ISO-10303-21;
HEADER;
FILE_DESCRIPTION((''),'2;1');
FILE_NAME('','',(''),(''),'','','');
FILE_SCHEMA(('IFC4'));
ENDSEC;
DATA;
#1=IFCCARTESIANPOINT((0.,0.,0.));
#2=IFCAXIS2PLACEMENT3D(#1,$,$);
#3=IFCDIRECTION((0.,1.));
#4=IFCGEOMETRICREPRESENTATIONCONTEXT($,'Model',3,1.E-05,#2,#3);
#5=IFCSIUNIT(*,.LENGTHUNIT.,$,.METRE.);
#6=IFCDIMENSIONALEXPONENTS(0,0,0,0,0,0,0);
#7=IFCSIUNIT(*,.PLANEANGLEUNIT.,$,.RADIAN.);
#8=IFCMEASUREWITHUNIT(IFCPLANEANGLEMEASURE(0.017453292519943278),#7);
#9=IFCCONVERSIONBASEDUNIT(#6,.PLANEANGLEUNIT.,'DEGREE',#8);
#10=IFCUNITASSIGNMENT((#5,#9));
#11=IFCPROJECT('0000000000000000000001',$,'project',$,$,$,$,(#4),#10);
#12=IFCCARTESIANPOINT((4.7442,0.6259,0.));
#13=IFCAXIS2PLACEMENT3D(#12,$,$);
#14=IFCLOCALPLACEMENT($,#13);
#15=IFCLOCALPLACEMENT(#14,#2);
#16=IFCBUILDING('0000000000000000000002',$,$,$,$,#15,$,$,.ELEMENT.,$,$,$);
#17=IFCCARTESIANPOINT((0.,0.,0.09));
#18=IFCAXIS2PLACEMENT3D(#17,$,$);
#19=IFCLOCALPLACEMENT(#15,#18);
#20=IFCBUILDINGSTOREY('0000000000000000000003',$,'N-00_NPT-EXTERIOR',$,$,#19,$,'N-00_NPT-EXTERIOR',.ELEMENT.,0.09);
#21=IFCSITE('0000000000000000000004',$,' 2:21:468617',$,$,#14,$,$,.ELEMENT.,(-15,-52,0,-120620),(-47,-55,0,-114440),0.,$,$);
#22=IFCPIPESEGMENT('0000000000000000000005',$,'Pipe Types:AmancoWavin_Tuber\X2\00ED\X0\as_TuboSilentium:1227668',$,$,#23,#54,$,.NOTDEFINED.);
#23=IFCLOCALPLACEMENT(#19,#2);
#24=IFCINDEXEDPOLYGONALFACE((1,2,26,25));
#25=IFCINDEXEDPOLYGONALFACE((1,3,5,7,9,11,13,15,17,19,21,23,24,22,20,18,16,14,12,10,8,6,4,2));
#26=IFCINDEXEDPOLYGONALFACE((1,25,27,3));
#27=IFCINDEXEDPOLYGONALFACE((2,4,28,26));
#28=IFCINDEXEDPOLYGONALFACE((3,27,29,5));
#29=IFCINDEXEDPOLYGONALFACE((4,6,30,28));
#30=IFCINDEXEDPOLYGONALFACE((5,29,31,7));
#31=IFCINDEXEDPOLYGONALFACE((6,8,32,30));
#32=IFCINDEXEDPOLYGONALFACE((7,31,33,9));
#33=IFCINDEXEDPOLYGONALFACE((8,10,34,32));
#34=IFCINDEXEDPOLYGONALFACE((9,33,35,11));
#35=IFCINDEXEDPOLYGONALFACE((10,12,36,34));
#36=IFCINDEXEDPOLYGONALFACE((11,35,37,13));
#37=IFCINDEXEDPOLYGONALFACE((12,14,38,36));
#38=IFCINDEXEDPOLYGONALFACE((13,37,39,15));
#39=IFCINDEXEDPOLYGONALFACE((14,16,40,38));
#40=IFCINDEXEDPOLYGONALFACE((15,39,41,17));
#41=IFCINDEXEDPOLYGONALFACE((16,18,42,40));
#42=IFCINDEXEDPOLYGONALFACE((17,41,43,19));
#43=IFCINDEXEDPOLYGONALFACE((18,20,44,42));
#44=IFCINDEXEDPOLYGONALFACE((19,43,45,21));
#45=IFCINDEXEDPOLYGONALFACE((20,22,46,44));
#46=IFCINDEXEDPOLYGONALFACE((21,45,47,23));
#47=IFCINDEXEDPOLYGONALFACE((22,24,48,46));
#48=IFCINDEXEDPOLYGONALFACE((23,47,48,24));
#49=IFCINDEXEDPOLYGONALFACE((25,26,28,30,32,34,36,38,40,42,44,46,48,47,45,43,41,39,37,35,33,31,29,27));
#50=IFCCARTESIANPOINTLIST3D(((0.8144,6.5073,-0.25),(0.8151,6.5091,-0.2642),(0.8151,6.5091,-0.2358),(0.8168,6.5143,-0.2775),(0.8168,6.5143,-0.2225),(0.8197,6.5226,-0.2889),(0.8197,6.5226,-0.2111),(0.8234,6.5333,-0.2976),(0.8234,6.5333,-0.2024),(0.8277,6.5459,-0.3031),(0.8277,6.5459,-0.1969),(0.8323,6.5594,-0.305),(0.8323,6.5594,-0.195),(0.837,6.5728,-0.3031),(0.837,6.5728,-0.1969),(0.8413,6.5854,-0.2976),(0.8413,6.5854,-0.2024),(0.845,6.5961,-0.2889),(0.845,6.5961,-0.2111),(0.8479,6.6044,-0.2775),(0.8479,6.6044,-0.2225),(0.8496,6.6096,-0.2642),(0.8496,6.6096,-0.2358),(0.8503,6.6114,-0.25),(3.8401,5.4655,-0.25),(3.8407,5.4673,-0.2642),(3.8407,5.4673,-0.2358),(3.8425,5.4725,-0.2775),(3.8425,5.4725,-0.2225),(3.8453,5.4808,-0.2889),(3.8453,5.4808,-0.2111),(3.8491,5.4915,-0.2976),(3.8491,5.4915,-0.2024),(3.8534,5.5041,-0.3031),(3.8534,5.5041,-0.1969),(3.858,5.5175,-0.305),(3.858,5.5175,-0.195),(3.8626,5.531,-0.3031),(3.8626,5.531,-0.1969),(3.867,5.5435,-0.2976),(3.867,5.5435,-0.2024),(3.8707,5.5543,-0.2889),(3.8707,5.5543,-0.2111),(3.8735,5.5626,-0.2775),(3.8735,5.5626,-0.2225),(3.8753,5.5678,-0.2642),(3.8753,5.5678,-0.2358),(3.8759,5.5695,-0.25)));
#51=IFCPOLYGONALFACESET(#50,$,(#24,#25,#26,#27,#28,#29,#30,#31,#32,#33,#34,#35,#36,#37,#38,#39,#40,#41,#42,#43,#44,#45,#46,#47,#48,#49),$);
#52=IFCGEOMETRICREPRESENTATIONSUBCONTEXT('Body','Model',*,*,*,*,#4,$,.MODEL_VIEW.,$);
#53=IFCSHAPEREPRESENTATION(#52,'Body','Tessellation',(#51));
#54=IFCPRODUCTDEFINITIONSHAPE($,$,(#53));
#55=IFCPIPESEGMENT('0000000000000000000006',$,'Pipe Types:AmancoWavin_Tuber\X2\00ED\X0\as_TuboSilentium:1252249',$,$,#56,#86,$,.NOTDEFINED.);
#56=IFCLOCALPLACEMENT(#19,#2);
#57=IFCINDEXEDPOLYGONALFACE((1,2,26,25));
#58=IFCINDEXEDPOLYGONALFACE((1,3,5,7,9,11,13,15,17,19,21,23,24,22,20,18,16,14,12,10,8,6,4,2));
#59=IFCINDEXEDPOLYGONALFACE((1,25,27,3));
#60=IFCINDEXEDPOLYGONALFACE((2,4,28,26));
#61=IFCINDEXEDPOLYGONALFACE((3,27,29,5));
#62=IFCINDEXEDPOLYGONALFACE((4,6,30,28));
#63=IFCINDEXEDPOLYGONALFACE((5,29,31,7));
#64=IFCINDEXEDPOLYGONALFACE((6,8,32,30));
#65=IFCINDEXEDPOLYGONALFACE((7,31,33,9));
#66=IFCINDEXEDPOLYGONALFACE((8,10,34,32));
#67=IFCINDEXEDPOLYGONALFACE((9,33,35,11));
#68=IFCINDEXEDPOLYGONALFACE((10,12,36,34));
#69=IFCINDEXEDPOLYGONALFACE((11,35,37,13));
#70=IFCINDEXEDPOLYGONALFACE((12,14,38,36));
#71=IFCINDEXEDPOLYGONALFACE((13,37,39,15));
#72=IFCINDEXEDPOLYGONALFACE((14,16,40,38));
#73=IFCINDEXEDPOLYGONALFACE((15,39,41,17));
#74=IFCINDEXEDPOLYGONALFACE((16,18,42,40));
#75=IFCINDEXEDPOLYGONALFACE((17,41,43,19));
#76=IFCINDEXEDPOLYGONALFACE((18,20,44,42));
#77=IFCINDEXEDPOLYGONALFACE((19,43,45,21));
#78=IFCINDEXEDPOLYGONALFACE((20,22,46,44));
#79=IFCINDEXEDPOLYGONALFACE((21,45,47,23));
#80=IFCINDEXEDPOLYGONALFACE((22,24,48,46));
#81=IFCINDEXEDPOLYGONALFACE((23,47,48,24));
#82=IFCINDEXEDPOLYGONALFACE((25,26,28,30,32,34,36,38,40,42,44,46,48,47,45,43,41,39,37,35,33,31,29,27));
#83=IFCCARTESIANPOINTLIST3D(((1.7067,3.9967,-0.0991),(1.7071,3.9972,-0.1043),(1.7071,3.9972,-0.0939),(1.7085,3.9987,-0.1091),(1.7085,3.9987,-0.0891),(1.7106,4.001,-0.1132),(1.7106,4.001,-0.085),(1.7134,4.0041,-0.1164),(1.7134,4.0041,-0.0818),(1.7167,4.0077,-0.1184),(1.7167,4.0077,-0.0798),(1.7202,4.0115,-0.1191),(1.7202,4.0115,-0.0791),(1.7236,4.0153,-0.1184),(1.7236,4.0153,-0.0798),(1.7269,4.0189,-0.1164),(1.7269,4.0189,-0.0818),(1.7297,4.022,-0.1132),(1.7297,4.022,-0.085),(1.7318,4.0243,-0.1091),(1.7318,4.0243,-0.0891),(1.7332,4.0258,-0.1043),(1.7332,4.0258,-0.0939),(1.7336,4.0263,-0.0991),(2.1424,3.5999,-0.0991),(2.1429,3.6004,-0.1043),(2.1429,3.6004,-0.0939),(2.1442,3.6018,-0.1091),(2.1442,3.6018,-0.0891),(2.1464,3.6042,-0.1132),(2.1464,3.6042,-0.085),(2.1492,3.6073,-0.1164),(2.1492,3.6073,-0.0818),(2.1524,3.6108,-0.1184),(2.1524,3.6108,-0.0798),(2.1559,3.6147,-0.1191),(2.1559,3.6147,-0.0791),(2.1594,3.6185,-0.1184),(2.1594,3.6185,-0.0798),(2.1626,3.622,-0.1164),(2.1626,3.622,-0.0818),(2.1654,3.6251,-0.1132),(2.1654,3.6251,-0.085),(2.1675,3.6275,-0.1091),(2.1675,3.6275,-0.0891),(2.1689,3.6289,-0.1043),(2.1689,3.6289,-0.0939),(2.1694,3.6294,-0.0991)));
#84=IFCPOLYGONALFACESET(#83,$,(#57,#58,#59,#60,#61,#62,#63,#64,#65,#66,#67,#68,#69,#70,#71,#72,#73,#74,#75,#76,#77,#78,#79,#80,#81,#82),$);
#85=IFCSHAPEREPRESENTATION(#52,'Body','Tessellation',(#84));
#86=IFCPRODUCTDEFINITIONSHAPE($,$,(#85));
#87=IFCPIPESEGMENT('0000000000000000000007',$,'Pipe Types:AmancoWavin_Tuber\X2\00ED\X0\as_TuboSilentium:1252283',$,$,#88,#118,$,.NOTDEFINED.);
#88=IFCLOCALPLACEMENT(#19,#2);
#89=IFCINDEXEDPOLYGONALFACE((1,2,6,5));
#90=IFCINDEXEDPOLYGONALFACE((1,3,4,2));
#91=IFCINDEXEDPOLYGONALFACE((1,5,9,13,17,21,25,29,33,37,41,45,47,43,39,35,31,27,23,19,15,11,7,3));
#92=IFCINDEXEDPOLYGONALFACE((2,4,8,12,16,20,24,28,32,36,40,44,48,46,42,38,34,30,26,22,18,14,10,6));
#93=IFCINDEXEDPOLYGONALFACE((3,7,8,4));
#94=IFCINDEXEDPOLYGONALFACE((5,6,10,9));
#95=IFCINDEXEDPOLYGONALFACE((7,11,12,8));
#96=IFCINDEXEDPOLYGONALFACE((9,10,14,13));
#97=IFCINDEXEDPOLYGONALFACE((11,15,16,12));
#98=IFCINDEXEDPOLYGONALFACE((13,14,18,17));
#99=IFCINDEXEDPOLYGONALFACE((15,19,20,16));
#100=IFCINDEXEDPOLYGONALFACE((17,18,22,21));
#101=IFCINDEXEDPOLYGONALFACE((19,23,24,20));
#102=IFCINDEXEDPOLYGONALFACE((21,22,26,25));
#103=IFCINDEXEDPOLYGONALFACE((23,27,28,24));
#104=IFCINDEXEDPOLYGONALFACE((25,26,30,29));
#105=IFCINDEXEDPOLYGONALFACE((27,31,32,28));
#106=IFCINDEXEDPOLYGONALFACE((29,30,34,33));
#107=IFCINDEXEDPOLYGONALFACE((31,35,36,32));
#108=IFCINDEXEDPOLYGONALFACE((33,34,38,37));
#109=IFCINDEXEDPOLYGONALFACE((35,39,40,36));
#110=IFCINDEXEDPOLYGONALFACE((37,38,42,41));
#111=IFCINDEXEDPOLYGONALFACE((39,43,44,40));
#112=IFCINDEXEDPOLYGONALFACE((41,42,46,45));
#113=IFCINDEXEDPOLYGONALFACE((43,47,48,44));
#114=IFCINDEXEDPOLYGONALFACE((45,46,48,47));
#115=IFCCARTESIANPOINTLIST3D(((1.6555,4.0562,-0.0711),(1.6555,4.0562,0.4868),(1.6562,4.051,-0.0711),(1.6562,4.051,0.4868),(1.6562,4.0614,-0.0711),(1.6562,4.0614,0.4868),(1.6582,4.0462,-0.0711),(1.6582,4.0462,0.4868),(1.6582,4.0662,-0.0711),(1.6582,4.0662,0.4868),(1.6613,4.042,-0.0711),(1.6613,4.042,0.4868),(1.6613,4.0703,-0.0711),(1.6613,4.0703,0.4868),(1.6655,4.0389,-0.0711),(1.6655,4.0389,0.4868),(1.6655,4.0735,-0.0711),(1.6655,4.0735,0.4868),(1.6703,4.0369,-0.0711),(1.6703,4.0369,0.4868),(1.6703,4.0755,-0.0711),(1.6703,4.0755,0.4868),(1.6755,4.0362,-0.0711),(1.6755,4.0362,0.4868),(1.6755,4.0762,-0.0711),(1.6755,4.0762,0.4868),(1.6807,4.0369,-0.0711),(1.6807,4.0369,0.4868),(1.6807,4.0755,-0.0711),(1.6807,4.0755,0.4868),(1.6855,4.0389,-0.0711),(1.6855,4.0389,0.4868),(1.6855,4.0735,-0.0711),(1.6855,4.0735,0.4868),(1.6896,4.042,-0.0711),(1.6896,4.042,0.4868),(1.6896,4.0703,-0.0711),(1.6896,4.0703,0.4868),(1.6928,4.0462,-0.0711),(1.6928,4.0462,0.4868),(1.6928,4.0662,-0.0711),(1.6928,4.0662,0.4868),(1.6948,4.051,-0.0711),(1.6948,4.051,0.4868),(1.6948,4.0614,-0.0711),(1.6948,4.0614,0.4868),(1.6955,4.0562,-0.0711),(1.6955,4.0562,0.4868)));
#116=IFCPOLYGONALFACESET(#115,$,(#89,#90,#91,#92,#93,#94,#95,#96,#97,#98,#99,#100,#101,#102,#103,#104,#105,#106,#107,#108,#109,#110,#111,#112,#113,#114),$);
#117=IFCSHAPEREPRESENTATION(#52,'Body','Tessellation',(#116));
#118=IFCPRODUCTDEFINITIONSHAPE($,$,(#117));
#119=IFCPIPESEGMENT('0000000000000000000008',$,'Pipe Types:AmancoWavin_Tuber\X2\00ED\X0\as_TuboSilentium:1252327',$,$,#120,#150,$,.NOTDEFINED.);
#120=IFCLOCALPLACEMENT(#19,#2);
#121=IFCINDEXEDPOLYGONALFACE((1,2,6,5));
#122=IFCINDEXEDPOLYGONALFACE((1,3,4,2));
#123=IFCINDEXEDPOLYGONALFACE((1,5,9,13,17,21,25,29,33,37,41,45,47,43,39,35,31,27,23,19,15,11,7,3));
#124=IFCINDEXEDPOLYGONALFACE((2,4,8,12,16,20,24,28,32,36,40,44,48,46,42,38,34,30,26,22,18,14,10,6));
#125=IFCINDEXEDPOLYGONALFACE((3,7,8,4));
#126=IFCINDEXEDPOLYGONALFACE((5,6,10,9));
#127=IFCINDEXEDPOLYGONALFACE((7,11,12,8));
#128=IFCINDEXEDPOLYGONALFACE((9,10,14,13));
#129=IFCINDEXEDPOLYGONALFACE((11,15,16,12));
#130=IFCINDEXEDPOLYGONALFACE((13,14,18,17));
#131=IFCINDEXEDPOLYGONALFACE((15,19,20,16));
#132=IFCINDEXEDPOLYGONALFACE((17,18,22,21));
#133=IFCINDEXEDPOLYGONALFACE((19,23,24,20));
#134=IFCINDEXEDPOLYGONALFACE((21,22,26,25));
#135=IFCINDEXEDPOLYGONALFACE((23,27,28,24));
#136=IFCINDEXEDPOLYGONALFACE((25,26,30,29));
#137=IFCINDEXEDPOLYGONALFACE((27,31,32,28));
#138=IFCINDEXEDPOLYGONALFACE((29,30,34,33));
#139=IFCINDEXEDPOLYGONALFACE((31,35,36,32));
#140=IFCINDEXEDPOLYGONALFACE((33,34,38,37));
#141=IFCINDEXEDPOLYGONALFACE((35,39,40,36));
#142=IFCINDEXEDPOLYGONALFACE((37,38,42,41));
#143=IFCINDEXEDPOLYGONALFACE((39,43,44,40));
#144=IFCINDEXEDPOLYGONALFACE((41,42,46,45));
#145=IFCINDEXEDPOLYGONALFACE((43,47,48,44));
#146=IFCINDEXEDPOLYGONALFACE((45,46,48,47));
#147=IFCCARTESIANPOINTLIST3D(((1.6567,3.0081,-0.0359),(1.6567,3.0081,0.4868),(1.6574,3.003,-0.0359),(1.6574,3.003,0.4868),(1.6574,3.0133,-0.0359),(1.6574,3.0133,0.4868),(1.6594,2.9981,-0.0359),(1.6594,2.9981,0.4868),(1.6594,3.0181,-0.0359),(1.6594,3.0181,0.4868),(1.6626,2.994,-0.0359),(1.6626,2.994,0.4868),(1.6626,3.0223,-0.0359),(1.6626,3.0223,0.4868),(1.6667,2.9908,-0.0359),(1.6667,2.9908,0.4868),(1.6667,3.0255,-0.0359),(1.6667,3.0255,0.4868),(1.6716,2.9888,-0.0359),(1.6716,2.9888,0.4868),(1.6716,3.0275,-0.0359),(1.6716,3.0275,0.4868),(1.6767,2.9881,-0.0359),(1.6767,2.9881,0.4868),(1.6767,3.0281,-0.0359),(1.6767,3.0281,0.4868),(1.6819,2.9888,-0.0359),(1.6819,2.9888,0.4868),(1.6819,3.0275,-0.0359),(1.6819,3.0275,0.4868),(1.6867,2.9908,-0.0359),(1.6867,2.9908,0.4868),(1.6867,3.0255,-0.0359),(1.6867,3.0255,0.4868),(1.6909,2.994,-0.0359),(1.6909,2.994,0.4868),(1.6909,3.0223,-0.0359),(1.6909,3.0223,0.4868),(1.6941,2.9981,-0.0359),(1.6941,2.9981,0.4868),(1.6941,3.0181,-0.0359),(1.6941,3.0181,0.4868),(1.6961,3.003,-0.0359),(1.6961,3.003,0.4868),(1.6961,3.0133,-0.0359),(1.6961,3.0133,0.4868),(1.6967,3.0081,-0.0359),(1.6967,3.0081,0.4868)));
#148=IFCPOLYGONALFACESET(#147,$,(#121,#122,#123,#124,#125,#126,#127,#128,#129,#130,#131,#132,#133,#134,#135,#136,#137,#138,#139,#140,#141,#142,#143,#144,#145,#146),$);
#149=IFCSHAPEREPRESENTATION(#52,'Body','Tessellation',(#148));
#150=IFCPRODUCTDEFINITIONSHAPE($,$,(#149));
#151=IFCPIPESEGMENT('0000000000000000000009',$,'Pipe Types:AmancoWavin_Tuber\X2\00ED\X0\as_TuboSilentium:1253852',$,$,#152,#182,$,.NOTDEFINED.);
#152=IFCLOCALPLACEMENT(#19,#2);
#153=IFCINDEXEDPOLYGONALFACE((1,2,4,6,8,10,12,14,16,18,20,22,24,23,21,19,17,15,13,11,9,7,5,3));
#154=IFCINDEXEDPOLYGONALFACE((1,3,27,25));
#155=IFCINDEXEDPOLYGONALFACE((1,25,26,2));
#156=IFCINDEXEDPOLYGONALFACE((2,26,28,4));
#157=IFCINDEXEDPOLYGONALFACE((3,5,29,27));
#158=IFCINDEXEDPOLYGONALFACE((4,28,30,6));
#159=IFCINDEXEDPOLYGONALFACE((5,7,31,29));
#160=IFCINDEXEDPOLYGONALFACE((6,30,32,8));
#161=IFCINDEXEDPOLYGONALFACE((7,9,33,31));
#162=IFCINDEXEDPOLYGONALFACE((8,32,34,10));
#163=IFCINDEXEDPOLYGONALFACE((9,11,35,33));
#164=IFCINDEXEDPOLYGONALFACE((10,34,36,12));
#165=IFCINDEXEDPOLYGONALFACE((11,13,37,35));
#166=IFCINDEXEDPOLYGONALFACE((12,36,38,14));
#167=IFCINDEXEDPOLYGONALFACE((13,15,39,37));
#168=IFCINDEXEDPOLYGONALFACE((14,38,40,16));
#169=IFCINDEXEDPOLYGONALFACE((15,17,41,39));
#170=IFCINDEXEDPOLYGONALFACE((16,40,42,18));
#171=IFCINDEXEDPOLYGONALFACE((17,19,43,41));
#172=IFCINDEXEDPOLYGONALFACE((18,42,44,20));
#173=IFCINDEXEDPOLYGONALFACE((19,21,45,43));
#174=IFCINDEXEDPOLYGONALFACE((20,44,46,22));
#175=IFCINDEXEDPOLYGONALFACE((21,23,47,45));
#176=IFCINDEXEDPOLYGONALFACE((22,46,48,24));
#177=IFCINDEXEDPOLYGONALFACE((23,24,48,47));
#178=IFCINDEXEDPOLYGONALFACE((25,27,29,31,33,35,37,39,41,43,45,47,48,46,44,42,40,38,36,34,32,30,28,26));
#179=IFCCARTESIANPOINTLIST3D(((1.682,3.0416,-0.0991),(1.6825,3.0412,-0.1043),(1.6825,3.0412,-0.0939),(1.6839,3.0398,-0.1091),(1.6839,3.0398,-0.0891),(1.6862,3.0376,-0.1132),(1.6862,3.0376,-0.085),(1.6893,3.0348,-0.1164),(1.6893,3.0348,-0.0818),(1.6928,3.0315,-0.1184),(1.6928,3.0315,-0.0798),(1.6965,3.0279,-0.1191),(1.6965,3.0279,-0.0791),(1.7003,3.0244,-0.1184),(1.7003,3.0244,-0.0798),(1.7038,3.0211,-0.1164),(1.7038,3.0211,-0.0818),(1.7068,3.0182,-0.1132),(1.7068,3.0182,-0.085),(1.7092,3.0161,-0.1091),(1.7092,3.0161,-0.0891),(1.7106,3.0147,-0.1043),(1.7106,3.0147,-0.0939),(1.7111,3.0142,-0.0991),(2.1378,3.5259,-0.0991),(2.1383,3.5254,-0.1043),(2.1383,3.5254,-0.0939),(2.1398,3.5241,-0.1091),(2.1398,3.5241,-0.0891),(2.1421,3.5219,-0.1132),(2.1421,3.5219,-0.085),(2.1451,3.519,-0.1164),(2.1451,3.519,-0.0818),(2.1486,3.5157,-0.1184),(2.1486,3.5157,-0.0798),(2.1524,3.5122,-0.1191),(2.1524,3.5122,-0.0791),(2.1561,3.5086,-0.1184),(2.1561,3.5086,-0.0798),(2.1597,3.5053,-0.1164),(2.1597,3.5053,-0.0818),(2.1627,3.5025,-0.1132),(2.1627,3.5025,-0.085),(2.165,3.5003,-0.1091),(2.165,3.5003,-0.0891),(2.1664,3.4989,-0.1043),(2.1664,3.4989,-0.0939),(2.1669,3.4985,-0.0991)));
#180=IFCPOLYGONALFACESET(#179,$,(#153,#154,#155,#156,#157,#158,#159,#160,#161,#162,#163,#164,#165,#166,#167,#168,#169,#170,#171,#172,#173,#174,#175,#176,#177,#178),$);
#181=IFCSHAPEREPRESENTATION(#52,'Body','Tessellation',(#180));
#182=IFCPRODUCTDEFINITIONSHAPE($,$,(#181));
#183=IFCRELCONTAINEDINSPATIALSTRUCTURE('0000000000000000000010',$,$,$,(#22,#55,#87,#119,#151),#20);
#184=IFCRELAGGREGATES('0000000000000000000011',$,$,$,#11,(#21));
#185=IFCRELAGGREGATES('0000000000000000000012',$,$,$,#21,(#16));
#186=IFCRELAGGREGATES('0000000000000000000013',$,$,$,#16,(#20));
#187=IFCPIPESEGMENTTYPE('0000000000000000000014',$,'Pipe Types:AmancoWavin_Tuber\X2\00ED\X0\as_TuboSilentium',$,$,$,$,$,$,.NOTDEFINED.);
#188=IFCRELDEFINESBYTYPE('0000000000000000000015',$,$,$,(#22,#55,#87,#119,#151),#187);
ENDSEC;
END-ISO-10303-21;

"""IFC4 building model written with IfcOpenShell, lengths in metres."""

from ifc_helpers import new_model, entity, si_unit, converted_unit, direction, frame, origin, place, context, subcontext, project, spatial, arc, indexed_curve, outline, extrude, type_object, element, save


model = new_model("IFC4")

# Units and contexts
model_context = context("Model", 3, precision=1e-05, world=origin(), true_north=direction((0.0, 1.0)))
body_context = subcontext(model_context, "Body", "Model", "MODEL_VIEW")
ifc_project = project(units=[si_unit("LENGTHUNIT", "METRE"), converted_unit("PLANEANGLEUNIT", "DEGREE", entity("IfcPlaneAngleMeasure", 0.017453292519943278), si_unit("PLANEANGLEUNIT", "RADIAN"), dimensions=[0, 0, 0, 0, 0, 0, 0])], contexts=[model_context])

# Site, building, storey
site_placement = place(None, frame((4.7442, 0.6259, 0.0)))
site = spatial("IfcSite", under=ifc_project, at=site_placement, Name=" 2:21:468617", CompositionType="ELEMENT", RefLatitude=(-15, -52, 0, -120620), RefLongitude=(-47, -55, 0, -114440), RefElevation=0.0)
building_placement = place(site_placement, origin())
building = spatial("IfcBuilding", under=site, at=building_placement, CompositionType="ELEMENT")
storey_placement = place(building_placement, frame((0.0, 0.0, 0.09)))
storey = spatial("IfcBuildingStorey", under=building, at=storey_placement, Name="N-00_NPT-EXTERIOR", LongName="N-00_NPT-EXTERIOR", CompositionType="ELEMENT", Elevation=0.09)

# Pipe segments
pipe_segment_type_1 = type_object("IfcPipeSegmentType", Name="Pipe Types:AmancoWavin_Tuberías_TuboSilentium", PredefinedType="NOTDEFINED")
pipe_segment_1_placement = place(storey_placement, origin())
element("IfcPipeSegment", 1, at=pipe_segment_1_placement, inside=storey, type_object=pipe_segment_type_1, Name="Pipe Types:AmancoWavin_Tuberías_TuboSilentium:1227668", PredefinedType="NOTDEFINED", context=body_context, shape_type="SweptSolid", body=[
    extrude(outline(indexed_curve([(0.055, 0.0), (0.0389, 0.0389), (0.0, 0.055), (-0.0389, 0.0389), (-0.055, 0.0), (-0.0389, -0.0389), (0.0, -0.055), (0.0389, -0.0389)], segments=[arc(1, 2, 3), arc(3, 4, 5), arc(5, 6, 7), arc(7, 8, 1)], self_intersect=False)), frame((0.8323, 6.5594, -0.25), z_axis=(0.945519, -0.325568, 0.0), x_axis=(-0.325568, -0.945519, 0.0)), (0.0, 0.0, 1.0), 3.2),
])
pipe_segment_2_placement = place(storey_placement, origin())
element("IfcPipeSegment", 2, at=pipe_segment_2_placement, inside=storey, type_object=pipe_segment_type_1, Name="Pipe Types:AmancoWavin_Tuberías_TuboSilentium:1252249", PredefinedType="NOTDEFINED", context=body_context, shape_type="SweptSolid", body=[
    extrude(outline(indexed_curve([(0.02, 0.0), (0.0141, 0.0141), (0.0, 0.02), (-0.0141, 0.0141), (-0.02, 0.0), (-0.0141, -0.0141), (0.0, -0.02), (0.0141, -0.0141)], segments=[arc(1, 2, 3), arc(3, 4, 5), arc(5, 6, 7), arc(7, 8, 1)], self_intersect=False)), frame((2.1559, 3.6147, -0.0991), z_axis=(-0.739321, 0.673354, 0.0), x_axis=(0.673354, 0.739321, 0.0)), (0.0, 0.0, 1.0), 0.5894),
])
pipe_segment_3_placement = place(storey_placement, origin())
element("IfcPipeSegment", 3, at=pipe_segment_3_placement, inside=storey, type_object=pipe_segment_type_1, Name="Pipe Types:AmancoWavin_Tuberías_TuboSilentium:1252283", PredefinedType="NOTDEFINED", context=body_context, shape_type="SweptSolid", body=[
    extrude(outline(indexed_curve([(0.02, 0.0), (0.0141, 0.0141), (0.0, 0.02), (-0.0141, 0.0141), (-0.02, 0.0), (-0.0141, -0.0141), (0.0, -0.02), (0.0141, -0.0141)], segments=[arc(1, 2, 3), arc(3, 4, 5), arc(5, 6, 7), arc(7, 8, 1)], self_intersect=False)), frame((1.6755, 4.0562, -0.0711), z_axis=(0.0, 0.0, 1.0), x_axis=(-1.0, 0.0, 0.0)), (0.0, 0.0, 1.0), 0.5579),
])
pipe_segment_4_placement = place(storey_placement, origin())
element("IfcPipeSegment", 4, at=pipe_segment_4_placement, inside=storey, type_object=pipe_segment_type_1, Name="Pipe Types:AmancoWavin_Tuberías_TuboSilentium:1252327", PredefinedType="NOTDEFINED", context=body_context, shape_type="SweptSolid", body=[
    extrude(outline(indexed_curve([(0.02, 0.0), (0.0141, 0.0141), (0.0, 0.02), (-0.0141, 0.0141), (-0.02, 0.0), (-0.0141, -0.0141), (0.0, -0.02), (0.0141, -0.0141)], segments=[arc(1, 2, 3), arc(3, 4, 5), arc(5, 6, 7), arc(7, 8, 1)], self_intersect=False)), frame((1.6767, 3.0081, -0.0359), z_axis=(0.0, 0.0, 1.0), x_axis=(-1.0, 0.0, 0.0)), (0.0, 0.0, 1.0), 0.5227),
])
pipe_segment_5_placement = place(storey_placement, origin())
element("IfcPipeSegment", 5, at=pipe_segment_5_placement, inside=storey, type_object=pipe_segment_type_1, Name="Pipe Types:AmancoWavin_Tuberías_TuboSilentium:1253852", PredefinedType="NOTDEFINED", context=body_context, shape_type="SweptSolid", body=[
    extrude(outline(indexed_curve([(0.02, 0.0), (0.0141, 0.0141), (0.0, 0.02), (-0.0141, 0.0141), (-0.02, 0.0), (-0.0141, -0.0141), (0.0, -0.02), (0.0141, -0.0141)], segments=[arc(1, 2, 3), arc(3, 4, 5), arc(5, 6, 7), arc(7, 8, 1)], self_intersect=False)), frame((1.6965, 3.0279, -0.0991), z_axis=(0.685413, 0.728154, 0.0), x_axis=(0.728154, -0.685413, 0.0)), (0.0, 0.0, 1.0), 0.665),
])

save(model, "model.ifc")
